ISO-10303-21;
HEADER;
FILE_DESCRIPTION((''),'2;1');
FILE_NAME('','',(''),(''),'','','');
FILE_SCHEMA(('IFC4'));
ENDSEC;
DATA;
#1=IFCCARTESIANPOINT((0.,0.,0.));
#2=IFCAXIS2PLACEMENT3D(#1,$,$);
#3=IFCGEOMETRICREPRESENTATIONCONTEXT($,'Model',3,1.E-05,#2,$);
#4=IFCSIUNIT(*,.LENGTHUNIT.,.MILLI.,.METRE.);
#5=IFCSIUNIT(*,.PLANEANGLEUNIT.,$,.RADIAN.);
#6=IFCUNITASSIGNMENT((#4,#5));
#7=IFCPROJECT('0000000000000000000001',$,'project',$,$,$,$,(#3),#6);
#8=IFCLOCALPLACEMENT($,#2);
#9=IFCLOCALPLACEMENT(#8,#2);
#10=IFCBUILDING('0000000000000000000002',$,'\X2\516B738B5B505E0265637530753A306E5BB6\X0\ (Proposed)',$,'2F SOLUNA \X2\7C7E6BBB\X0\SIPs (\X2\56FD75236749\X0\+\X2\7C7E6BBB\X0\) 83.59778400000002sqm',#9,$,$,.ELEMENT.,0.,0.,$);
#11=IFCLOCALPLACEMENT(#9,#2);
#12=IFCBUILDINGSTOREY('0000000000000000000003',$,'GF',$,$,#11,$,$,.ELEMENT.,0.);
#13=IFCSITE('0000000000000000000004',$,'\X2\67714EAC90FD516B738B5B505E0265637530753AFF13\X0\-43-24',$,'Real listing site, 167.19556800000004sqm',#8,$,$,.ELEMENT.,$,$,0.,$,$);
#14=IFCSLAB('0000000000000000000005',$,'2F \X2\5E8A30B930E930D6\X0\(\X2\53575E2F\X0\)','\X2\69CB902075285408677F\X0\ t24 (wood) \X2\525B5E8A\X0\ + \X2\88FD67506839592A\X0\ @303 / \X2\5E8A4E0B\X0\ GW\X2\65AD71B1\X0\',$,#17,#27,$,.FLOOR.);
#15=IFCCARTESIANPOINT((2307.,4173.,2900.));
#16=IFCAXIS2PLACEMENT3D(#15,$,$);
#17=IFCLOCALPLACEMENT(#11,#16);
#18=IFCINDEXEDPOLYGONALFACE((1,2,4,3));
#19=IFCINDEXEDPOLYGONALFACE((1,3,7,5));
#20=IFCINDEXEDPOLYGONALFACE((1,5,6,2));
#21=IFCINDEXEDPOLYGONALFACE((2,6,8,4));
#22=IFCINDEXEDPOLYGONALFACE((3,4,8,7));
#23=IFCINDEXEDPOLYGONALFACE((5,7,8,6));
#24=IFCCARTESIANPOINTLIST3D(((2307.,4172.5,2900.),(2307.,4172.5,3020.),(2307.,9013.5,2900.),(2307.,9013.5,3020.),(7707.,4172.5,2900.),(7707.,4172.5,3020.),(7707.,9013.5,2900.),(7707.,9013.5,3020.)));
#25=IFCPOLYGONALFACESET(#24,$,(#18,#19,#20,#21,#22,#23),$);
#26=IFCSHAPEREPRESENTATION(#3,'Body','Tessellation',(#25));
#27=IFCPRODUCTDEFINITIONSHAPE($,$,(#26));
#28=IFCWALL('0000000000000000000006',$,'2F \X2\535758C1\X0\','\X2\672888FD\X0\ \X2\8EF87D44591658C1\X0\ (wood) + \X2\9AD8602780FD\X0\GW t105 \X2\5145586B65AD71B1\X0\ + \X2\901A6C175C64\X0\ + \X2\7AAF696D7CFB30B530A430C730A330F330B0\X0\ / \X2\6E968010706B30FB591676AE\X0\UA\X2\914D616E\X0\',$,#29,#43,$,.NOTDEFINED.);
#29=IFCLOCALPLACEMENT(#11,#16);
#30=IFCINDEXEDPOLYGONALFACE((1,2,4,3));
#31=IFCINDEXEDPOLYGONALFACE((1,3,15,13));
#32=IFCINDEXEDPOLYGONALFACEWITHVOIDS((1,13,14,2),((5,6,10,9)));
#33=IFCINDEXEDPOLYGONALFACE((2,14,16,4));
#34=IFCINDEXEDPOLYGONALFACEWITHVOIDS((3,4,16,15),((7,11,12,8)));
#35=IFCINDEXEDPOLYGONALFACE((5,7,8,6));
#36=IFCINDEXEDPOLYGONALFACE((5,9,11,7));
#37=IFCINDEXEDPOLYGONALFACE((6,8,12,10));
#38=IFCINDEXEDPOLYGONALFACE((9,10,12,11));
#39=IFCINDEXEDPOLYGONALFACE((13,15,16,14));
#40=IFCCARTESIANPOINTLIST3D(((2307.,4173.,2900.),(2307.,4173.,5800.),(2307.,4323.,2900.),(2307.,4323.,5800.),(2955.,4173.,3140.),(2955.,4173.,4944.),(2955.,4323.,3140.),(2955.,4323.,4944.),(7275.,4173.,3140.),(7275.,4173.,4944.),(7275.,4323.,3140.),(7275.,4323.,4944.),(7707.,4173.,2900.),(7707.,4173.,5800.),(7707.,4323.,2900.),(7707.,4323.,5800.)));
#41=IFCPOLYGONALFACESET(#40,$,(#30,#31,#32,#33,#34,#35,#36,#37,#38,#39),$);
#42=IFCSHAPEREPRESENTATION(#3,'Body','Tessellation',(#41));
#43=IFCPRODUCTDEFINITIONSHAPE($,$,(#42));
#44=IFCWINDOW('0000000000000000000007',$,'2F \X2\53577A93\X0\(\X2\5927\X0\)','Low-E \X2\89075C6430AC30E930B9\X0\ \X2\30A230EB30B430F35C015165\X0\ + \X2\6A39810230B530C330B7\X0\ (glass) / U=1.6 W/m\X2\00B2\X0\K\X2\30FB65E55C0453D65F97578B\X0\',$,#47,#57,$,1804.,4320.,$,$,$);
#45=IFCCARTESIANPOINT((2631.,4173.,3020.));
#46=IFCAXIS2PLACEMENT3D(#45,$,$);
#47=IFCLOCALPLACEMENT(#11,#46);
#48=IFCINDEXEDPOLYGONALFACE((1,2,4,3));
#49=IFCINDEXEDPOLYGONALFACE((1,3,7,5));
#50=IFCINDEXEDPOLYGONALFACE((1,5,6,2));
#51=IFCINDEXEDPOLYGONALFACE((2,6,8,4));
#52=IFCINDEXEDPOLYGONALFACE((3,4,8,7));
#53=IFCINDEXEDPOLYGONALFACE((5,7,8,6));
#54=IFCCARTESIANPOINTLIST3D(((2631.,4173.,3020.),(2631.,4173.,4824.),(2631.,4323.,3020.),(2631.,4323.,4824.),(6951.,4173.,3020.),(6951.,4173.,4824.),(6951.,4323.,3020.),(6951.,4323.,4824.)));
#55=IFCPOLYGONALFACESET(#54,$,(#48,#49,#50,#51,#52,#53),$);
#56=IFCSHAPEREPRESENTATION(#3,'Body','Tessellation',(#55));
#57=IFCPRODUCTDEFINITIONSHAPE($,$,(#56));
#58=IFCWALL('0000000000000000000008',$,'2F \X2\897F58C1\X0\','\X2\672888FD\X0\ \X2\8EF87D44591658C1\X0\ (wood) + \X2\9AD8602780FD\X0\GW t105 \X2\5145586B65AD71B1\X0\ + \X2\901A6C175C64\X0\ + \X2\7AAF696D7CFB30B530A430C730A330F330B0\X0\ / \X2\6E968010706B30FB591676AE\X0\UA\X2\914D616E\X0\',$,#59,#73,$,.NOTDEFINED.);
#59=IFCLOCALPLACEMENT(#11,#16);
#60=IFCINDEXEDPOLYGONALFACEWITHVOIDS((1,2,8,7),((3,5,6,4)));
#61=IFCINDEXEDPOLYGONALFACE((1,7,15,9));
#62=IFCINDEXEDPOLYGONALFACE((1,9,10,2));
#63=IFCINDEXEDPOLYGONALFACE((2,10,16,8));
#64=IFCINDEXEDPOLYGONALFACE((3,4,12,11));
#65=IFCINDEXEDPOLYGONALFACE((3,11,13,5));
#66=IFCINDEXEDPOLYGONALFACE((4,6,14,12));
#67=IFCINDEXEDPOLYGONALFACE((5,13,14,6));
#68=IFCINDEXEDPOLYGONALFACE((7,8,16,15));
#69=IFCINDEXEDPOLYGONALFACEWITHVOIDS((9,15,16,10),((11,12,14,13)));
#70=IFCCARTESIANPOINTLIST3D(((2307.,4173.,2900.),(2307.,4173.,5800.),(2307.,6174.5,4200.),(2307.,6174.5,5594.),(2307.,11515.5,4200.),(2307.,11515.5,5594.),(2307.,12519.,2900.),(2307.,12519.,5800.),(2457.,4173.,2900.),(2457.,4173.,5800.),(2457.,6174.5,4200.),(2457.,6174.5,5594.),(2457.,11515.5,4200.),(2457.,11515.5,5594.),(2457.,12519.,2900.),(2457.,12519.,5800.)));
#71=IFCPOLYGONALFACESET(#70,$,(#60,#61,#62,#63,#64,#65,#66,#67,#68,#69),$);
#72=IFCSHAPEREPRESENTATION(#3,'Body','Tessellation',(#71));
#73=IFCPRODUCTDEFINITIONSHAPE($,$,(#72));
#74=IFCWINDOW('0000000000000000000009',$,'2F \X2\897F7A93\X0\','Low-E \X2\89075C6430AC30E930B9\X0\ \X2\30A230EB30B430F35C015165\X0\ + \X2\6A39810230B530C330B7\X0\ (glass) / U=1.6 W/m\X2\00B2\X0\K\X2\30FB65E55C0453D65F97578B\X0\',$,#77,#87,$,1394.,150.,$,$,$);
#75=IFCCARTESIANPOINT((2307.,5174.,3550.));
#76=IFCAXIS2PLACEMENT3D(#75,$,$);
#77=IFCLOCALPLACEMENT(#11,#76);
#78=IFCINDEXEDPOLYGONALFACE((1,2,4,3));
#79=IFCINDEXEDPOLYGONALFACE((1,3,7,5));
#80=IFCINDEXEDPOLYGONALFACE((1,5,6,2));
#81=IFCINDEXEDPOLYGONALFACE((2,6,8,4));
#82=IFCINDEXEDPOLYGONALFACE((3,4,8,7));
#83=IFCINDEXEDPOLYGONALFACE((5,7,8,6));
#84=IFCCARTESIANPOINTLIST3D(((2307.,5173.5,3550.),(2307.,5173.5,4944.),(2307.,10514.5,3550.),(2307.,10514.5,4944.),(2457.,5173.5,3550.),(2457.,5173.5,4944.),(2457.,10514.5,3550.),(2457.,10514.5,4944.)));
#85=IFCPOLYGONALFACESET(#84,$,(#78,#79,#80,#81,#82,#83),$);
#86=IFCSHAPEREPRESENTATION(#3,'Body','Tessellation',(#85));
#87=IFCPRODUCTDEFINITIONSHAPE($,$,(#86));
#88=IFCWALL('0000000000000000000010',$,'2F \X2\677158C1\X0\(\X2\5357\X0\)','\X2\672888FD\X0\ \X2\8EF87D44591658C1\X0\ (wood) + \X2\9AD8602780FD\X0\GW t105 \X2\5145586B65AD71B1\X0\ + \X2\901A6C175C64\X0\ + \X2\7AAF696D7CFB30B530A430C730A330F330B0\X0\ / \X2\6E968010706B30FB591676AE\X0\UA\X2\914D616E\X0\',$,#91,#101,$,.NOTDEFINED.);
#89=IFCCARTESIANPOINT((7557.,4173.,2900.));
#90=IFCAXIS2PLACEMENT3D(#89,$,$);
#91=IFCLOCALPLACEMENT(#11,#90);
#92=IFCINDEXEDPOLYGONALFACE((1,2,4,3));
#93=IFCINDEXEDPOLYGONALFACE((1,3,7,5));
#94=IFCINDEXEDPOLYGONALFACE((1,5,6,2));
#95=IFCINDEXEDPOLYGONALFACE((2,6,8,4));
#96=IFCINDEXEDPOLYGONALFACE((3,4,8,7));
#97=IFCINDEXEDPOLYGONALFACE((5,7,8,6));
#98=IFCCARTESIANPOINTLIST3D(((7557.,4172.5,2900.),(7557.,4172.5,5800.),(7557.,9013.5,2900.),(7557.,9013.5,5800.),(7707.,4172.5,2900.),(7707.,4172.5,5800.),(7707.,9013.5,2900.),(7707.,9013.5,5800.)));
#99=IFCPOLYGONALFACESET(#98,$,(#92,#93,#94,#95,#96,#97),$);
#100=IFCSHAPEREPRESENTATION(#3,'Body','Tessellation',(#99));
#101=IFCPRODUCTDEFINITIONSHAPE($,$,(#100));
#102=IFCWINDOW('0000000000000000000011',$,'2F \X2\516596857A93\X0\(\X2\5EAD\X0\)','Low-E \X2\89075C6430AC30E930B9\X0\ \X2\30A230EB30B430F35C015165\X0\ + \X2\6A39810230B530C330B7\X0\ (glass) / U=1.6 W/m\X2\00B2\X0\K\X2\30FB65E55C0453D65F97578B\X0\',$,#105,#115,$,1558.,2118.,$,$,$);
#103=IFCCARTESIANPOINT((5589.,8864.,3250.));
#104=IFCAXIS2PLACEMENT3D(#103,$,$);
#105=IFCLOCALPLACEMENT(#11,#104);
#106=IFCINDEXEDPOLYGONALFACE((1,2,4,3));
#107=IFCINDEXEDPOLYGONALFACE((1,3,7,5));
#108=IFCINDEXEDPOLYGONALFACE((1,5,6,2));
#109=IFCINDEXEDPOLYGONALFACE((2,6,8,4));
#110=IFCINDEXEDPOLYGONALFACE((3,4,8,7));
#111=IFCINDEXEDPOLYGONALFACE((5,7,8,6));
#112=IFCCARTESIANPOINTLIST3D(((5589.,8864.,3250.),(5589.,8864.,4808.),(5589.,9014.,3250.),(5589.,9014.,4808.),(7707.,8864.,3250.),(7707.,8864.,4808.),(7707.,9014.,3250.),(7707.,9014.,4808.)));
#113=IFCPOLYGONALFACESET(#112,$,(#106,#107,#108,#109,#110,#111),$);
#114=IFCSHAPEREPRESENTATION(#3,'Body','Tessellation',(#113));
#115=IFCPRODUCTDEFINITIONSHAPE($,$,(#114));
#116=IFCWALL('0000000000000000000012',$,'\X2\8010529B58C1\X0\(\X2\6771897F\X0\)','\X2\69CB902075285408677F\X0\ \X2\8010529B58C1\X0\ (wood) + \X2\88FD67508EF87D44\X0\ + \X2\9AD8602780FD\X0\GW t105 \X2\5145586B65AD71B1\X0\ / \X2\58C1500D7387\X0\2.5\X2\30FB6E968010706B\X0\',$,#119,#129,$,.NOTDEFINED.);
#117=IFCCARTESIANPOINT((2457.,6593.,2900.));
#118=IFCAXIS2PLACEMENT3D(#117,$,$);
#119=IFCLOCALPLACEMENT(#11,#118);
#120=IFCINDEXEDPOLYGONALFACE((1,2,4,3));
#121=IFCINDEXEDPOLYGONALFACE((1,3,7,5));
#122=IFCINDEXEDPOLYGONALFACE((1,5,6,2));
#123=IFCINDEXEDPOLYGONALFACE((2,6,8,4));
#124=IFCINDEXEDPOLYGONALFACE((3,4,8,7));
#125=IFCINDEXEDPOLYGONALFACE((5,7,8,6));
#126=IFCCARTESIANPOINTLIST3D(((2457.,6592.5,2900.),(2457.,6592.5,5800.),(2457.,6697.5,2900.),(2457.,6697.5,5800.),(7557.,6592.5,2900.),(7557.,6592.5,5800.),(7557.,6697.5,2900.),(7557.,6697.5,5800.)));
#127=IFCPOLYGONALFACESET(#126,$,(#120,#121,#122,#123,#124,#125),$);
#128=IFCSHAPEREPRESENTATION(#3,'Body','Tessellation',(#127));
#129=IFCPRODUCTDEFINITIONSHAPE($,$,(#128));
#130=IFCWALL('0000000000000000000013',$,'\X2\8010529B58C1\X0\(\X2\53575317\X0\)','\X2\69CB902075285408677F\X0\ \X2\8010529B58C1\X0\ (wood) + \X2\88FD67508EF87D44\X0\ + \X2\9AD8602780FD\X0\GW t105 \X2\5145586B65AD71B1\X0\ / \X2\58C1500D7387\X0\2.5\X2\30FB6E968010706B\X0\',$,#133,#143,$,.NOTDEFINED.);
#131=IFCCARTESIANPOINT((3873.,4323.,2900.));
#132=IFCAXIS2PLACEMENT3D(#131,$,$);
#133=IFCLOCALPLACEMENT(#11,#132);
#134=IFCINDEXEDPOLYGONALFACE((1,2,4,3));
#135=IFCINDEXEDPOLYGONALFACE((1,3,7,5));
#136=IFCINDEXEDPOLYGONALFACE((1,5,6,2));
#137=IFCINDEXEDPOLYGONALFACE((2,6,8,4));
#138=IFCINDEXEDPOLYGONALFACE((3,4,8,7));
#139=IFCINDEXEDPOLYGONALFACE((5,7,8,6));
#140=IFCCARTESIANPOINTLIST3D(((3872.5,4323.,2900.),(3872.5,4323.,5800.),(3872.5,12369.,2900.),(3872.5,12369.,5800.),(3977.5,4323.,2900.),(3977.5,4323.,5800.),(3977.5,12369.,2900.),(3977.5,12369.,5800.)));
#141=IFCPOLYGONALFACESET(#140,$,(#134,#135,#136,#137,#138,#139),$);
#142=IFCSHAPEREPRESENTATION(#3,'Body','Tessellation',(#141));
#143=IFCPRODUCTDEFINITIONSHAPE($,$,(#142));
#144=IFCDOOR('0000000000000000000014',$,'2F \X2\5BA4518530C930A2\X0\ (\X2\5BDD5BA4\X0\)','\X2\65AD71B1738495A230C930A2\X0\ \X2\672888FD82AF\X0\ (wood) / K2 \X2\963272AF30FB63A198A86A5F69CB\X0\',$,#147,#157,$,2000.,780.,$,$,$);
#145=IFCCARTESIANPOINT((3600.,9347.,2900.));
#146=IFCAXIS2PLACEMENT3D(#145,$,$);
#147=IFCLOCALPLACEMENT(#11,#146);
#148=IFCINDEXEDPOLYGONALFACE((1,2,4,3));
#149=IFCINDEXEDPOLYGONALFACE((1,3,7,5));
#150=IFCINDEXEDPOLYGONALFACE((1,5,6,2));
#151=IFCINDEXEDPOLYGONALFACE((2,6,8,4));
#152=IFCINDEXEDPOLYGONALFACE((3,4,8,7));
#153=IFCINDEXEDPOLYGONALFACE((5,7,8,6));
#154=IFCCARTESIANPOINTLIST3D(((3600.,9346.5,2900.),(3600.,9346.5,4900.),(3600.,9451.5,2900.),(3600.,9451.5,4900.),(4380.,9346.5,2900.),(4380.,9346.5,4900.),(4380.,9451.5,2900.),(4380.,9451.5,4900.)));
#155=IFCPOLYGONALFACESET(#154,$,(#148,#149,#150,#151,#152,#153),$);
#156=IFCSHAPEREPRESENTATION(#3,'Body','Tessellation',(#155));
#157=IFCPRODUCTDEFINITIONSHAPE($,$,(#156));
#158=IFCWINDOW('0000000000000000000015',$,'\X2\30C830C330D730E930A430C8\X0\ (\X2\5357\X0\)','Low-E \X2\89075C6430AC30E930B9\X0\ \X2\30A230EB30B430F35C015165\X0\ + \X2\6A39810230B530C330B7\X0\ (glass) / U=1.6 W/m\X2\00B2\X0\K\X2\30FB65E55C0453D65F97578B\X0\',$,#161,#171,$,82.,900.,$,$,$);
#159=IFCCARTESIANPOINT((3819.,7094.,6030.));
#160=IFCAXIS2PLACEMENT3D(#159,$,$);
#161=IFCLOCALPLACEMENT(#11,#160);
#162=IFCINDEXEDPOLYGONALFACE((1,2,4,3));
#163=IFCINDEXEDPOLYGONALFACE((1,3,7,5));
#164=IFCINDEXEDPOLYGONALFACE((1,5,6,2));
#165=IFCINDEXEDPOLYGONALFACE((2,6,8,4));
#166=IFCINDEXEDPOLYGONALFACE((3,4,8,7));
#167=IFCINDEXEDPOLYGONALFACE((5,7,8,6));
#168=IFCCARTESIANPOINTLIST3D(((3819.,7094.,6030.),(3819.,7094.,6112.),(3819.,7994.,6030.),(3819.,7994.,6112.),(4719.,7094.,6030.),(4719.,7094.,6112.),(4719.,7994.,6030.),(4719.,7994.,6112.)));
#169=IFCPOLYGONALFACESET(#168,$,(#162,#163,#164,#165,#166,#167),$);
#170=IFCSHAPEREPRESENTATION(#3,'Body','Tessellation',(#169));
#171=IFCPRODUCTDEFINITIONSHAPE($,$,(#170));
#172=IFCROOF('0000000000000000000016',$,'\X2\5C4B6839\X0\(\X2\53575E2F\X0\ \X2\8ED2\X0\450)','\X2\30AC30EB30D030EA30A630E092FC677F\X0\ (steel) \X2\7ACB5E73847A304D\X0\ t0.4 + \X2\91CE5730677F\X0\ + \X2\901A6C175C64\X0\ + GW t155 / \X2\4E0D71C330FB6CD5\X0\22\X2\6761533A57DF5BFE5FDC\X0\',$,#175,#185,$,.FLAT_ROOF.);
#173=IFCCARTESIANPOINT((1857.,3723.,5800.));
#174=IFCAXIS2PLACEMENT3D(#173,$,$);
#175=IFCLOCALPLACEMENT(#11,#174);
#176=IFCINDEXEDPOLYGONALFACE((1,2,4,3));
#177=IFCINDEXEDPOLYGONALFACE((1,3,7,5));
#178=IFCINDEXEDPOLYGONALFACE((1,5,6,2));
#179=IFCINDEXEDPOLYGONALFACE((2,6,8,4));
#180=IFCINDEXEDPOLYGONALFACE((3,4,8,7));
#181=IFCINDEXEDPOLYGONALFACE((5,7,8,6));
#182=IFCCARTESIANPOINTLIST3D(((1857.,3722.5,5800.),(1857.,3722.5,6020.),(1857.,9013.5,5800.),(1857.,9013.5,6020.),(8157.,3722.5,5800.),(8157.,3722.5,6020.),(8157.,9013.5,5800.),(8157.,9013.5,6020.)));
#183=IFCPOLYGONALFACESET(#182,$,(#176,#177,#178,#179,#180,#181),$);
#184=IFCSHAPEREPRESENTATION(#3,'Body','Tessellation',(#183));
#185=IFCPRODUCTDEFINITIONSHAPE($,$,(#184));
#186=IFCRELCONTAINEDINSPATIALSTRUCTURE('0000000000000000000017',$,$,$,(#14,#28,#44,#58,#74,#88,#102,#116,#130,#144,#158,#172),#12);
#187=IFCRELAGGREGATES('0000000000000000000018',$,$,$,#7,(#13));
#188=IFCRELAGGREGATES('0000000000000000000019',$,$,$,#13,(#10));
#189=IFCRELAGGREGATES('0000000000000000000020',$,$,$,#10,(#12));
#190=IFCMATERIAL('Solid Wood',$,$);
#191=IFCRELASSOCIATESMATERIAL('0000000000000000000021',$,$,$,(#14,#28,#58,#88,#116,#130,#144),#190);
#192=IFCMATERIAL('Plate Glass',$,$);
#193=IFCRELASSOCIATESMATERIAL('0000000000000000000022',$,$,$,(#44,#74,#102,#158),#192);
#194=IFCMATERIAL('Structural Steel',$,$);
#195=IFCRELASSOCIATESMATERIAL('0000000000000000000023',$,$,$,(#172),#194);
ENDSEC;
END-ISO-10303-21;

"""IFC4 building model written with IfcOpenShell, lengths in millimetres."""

from ifc_helpers import new_model, si_unit, frame, frame_2d, origin, place, context, project, spatial, rectangle, extrude, material, element, fill, save


model = new_model("IFC4")

# Units and contexts
model_context = context("Model", 3, precision=1e-05, world=origin())
ifc_project = project(units=[si_unit("LENGTHUNIT", "METRE", prefix="MILLI"), si_unit("PLANEANGLEUNIT", "RADIAN")], contexts=[model_context])

# Site, building, storey
site_placement = place(None, origin())
site = spatial("IfcSite", under=ifc_project, at=site_placement, Name="東京都八王子市散田町３-43-24", ObjectType="Real listing site, 167.19556800000004sqm", CompositionType="ELEMENT", RefElevation=0.0)
building_placement = place(site_placement, origin())
building = spatial("IfcBuilding", under=site, at=building_placement, Name="八王子市散田町の家 (Proposed)", ObjectType="2F SOLUNA 籾殻SIPs (国産杉+籾殻) 83.59778400000002sqm", CompositionType="ELEMENT", ElevationOfRefHeight=0.0, ElevationOfTerrain=0.0)
storey_placement = place(building_placement, origin())
storey = spatial("IfcBuildingStorey", under=building, at=storey_placement, Name="GF", CompositionType="ELEMENT", Elevation=0.0)

# Slab
ifc_material_1 = material(Name="Solid Wood")
slab_placement = place(storey_placement, frame((2307.0, 4173.0, 2900.0)))
element("IfcSlab", 1, at=slab_placement, inside=storey, material=ifc_material_1, Name="2F 床スラブ(南帯)", Description="構造用合板 t24 (wood) 剛床 + 製材根太 @303 / 床下 GW断熱", PredefinedType="FLOOR", context=model_context, shape_type="SweptSolid", body=[
    extrude(rectangle(XDim=5400.0, YDim=4841.0, at=frame_2d((2700.0, 2420.0))), frame((2307.0, 4173.0, 2900.0)), (0.0, 0.0, 1.0), 120.0),
])

# Walls, openings, windows
wall_1_placement = place(storey_placement, frame((2307.0, 4173.0, 2900.0)))
wall_1 = element("IfcWall", 2, at=wall_1_placement, inside=storey, material=ifc_material_1, Name="2F 南壁", Description="木製 軸組外壁 (wood) + 高性能GW t105 充填断熱 + 通気層 + 窯業系サイディング / 準耐火・外皮UA配慮", PredefinedType="NOTDEFINED", context=model_context, shape_type="SweptSolid", body=[
    extrude(rectangle(XDim=5400.0, YDim=150.0, at=frame_2d((2700.0, 75.0))), frame((2307.0, 4173.0, 2900.0)), (0.0, 0.0, 1.0), 2900.0),
])
opening_1_placement = place(storey_placement, frame((2631.0, 4173.0, 3020.0)))
opening_1 = element("IfcOpeningElement", 3, at=opening_1_placement, cuts=wall_1, PredefinedType="NOTDEFINED", context=model_context, shape_type="SweptSolid", body=[
    extrude(rectangle(XDim=4320.0, YDim=150.0, at=frame_2d((2160.0, 75.0))), frame((2631.0, 4173.0, 3020.0)), (0.0, 0.0, 1.0), 1804.0),
])
ifc_material_2 = material(Name="Plate Glass")
window_1_placement = place(storey_placement, frame((2631.0, 4173.0, 3020.0)))
window_1 = element("IfcWindow", 4, at=window_1_placement, inside=storey, material=ifc_material_2, Name="2F 南窓(大)", Description="Low-E 複層ガラス アルゴン封入 + 樹脂サッシ (glass) / U=1.6 W/m²K・日射取得型", OverallHeight=1804.0, OverallWidth=4320.0, context=model_context, shape_type="SweptSolid", body=[
    extrude(rectangle(XDim=4320.0, YDim=150.0, at=frame_2d((2160.0, 75.0))), frame((2631.0, 4173.0, 3020.0)), (0.0, 0.0, 1.0), 1804.0),
])
fill(opening_1, window_1)
wall_2_placement = place(storey_placement, frame((2307.0, 4173.0, 2900.0)))
wall_2 = element("IfcWall", 5, at=wall_2_placement, inside=storey, material=ifc_material_1, Name="2F 西壁", Description="木製 軸組外壁 (wood) + 高性能GW t105 充填断熱 + 通気層 + 窯業系サイディング / 準耐火・外皮UA配慮", PredefinedType="NOTDEFINED", context=model_context, shape_type="SweptSolid", body=[
    extrude(rectangle(XDim=150.0, YDim=8346.0, at=frame_2d((75.0, 4173.0))), frame((2307.0, 4173.0, 2900.0)), (0.0, 0.0, 1.0), 2900.0),
])
opening_2_placement = place(storey_placement, frame((2307.0, 5174.0, 3550.0)))
opening_2 = element("IfcOpeningElement", 6, at=opening_2_placement, cuts=wall_2, PredefinedType="NOTDEFINED", context=model_context, shape_type="SweptSolid", body=[
    extrude(rectangle(XDim=150.0, YDim=5341.0, at=frame_2d((75.0, 2670.0))), frame((2307.0, 5174.0, 3550.0)), (0.0, 0.0, 1.0), 1394.0),
])
window_2_placement = place(storey_placement, frame((2307.0, 5174.0, 3550.0)))
window_2 = element("IfcWindow", 7, at=window_2_placement, inside=storey, material=ifc_material_2, Name="2F 西窓", Description="Low-E 複層ガラス アルゴン封入 + 樹脂サッシ (glass) / U=1.6 W/m²K・日射取得型", OverallHeight=1394.0, OverallWidth=150.0, context=model_context, shape_type="SweptSolid", body=[
    extrude(rectangle(XDim=150.0, YDim=5341.0, at=frame_2d((75.0, 2670.0))), frame((2307.0, 5174.0, 3550.0)), (0.0, 0.0, 1.0), 1394.0),
])
fill(opening_2, window_2)
wall_3_placement = place(storey_placement, frame((7557.0, 4173.0, 2900.0)))
wall_3 = element("IfcWall", 8, at=wall_3_placement, inside=storey, material=ifc_material_1, Name="2F 東壁(南)", Description="木製 軸組外壁 (wood) + 高性能GW t105 充填断熱 + 通気層 + 窯業系サイディング / 準耐火・外皮UA配慮", PredefinedType="NOTDEFINED", context=model_context, shape_type="SweptSolid", body=[
    extrude(rectangle(XDim=150.0, YDim=4841.0, at=frame_2d((75.0, 2420.0))), frame((7557.0, 4173.0, 2900.0)), (0.0, 0.0, 1.0), 2900.0),
])
opening_3_placement = place(storey_placement, frame((5589.0, 8864.0, 3250.0)))
opening_3 = element("IfcOpeningElement", 9, at=opening_3_placement, cuts=wall_3, PredefinedType="NOTDEFINED", context=model_context, shape_type="SweptSolid", body=[
    extrude(rectangle(XDim=2118.0, YDim=150.0, at=frame_2d((1059.0, 75.0))), frame((5589.0, 8864.0, 3250.0)), (0.0, 0.0, 1.0), 1558.0),
])
window_3_placement = place(storey_placement, frame((5589.0, 8864.0, 3250.0)))
window_3 = element("IfcWindow", 10, at=window_3_placement, inside=storey, material=ifc_material_2, Name="2F 入隅窓(庭)", Description="Low-E 複層ガラス アルゴン封入 + 樹脂サッシ (glass) / U=1.6 W/m²K・日射取得型", OverallHeight=1558.0, OverallWidth=2118.0, context=model_context, shape_type="SweptSolid", body=[
    extrude(rectangle(XDim=2118.0, YDim=150.0, at=frame_2d((1059.0, 75.0))), frame((5589.0, 8864.0, 3250.0)), (0.0, 0.0, 1.0), 1558.0),
])
fill(opening_3, window_3)

# Wall
wall_4_placement = place(storey_placement, frame((2457.0, 6593.0, 2900.0)))
element("IfcWall", 11, at=wall_4_placement, inside=storey, material=ifc_material_1, Name="耐力壁(東西)", Description="構造用合板 耐力壁 (wood) + 製材軸組 + 高性能GW t105 充填断熱 / 壁倍率2.5・準耐火", PredefinedType="NOTDEFINED", context=model_context, shape_type="SweptSolid", body=[
    extrude(rectangle(XDim=5100.0, YDim=105.0, at=frame_2d((2550.0, 52.0))), frame((2457.0, 6593.0, 2900.0)), (0.0, 0.0, 1.0), 2900.0),
])

# Wall, opening, door
wall_5_placement = place(storey_placement, frame((3873.0, 4323.0, 2900.0)))
wall_5 = element("IfcWall", 12, at=wall_5_placement, inside=storey, material=ifc_material_1, Name="耐力壁(南北)", Description="構造用合板 耐力壁 (wood) + 製材軸組 + 高性能GW t105 充填断熱 / 壁倍率2.5・準耐火", PredefinedType="NOTDEFINED", context=model_context, shape_type="SweptSolid", body=[
    extrude(rectangle(XDim=105.0, YDim=8046.0, at=frame_2d((52.0, 4023.0))), frame((3873.0, 4323.0, 2900.0)), (0.0, 0.0, 1.0), 2900.0),
])
opening_4_placement = place(storey_placement, frame((3600.0, 9347.0, 2900.0)))
opening_4 = element("IfcOpeningElement", 13, at=opening_4_placement, cuts=wall_5, PredefinedType="NOTDEFINED", context=model_context, shape_type="SweptSolid", body=[
    extrude(rectangle(XDim=780.0, YDim=105.0, at=frame_2d((390.0, 52.0))), frame((3600.0, 9347.0, 2900.0)), (0.0, 0.0, 1.0), 2000.0),
])
door_placement = place(storey_placement, frame((3600.0, 9347.0, 2900.0)))
door = element("IfcDoor", 14, at=door_placement, inside=storey, material=ifc_material_1, Name="2F 室内ドア (寝室)", Description="断熱玄関ドア 木製芯 (wood) / K2 防犯・採風機構", OverallHeight=2000.0, OverallWidth=780.0, context=model_context, shape_type="SweptSolid", body=[
    extrude(rectangle(XDim=780.0, YDim=105.0, at=frame_2d((390.0, 52.0))), frame((3600.0, 9347.0, 2900.0)), (0.0, 0.0, 1.0), 2000.0),
])
fill(opening_4, door)

# Window
window_4_placement = place(storey_placement, frame((3819.0, 7094.0, 6030.0)))
element("IfcWindow", 15, at=window_4_placement, inside=storey, material=ifc_material_2, Name="トップライト (南)", Description="Low-E 複層ガラス アルゴン封入 + 樹脂サッシ (glass) / U=1.6 W/m²K・日射取得型", OverallHeight=82.0, OverallWidth=900.0, context=model_context, shape_type="SweptSolid", body=[
    extrude(rectangle(XDim=900.0, YDim=900.0, at=frame_2d((450.0, 450.0))), frame((3819.0, 7094.0, 6030.0)), (0.0, 0.0, 1.0), 82.0),
])

# Roof
ifc_material_3 = material(Name="Structural Steel")
for number, where, name in (
    (16, (1857.0, 3723.0, 5800.0), "屋根(南帯 軒450)"),
):
    element("IfcRoof", number, at=place(storey_placement, frame(where)), inside=storey, material=ifc_material_3, Name=name, Description="ガルバリウム鋼板 (steel) 立平葺き t0.4 + 野地板 + 通気層 + GW t155 / 不燃・法22条区域対応", PredefinedType="FLAT_ROOF", context=model_context, shape_type="SweptSolid", body=[
        extrude(rectangle(XDim=6300.0, YDim=5291.0, at=frame_2d((3150.0, 2645.0))), frame((1857.0, 3723.0, 5800.0)), (0.0, 0.0, 1.0), 220.0),
    ])

save(model, "model.ifc")
